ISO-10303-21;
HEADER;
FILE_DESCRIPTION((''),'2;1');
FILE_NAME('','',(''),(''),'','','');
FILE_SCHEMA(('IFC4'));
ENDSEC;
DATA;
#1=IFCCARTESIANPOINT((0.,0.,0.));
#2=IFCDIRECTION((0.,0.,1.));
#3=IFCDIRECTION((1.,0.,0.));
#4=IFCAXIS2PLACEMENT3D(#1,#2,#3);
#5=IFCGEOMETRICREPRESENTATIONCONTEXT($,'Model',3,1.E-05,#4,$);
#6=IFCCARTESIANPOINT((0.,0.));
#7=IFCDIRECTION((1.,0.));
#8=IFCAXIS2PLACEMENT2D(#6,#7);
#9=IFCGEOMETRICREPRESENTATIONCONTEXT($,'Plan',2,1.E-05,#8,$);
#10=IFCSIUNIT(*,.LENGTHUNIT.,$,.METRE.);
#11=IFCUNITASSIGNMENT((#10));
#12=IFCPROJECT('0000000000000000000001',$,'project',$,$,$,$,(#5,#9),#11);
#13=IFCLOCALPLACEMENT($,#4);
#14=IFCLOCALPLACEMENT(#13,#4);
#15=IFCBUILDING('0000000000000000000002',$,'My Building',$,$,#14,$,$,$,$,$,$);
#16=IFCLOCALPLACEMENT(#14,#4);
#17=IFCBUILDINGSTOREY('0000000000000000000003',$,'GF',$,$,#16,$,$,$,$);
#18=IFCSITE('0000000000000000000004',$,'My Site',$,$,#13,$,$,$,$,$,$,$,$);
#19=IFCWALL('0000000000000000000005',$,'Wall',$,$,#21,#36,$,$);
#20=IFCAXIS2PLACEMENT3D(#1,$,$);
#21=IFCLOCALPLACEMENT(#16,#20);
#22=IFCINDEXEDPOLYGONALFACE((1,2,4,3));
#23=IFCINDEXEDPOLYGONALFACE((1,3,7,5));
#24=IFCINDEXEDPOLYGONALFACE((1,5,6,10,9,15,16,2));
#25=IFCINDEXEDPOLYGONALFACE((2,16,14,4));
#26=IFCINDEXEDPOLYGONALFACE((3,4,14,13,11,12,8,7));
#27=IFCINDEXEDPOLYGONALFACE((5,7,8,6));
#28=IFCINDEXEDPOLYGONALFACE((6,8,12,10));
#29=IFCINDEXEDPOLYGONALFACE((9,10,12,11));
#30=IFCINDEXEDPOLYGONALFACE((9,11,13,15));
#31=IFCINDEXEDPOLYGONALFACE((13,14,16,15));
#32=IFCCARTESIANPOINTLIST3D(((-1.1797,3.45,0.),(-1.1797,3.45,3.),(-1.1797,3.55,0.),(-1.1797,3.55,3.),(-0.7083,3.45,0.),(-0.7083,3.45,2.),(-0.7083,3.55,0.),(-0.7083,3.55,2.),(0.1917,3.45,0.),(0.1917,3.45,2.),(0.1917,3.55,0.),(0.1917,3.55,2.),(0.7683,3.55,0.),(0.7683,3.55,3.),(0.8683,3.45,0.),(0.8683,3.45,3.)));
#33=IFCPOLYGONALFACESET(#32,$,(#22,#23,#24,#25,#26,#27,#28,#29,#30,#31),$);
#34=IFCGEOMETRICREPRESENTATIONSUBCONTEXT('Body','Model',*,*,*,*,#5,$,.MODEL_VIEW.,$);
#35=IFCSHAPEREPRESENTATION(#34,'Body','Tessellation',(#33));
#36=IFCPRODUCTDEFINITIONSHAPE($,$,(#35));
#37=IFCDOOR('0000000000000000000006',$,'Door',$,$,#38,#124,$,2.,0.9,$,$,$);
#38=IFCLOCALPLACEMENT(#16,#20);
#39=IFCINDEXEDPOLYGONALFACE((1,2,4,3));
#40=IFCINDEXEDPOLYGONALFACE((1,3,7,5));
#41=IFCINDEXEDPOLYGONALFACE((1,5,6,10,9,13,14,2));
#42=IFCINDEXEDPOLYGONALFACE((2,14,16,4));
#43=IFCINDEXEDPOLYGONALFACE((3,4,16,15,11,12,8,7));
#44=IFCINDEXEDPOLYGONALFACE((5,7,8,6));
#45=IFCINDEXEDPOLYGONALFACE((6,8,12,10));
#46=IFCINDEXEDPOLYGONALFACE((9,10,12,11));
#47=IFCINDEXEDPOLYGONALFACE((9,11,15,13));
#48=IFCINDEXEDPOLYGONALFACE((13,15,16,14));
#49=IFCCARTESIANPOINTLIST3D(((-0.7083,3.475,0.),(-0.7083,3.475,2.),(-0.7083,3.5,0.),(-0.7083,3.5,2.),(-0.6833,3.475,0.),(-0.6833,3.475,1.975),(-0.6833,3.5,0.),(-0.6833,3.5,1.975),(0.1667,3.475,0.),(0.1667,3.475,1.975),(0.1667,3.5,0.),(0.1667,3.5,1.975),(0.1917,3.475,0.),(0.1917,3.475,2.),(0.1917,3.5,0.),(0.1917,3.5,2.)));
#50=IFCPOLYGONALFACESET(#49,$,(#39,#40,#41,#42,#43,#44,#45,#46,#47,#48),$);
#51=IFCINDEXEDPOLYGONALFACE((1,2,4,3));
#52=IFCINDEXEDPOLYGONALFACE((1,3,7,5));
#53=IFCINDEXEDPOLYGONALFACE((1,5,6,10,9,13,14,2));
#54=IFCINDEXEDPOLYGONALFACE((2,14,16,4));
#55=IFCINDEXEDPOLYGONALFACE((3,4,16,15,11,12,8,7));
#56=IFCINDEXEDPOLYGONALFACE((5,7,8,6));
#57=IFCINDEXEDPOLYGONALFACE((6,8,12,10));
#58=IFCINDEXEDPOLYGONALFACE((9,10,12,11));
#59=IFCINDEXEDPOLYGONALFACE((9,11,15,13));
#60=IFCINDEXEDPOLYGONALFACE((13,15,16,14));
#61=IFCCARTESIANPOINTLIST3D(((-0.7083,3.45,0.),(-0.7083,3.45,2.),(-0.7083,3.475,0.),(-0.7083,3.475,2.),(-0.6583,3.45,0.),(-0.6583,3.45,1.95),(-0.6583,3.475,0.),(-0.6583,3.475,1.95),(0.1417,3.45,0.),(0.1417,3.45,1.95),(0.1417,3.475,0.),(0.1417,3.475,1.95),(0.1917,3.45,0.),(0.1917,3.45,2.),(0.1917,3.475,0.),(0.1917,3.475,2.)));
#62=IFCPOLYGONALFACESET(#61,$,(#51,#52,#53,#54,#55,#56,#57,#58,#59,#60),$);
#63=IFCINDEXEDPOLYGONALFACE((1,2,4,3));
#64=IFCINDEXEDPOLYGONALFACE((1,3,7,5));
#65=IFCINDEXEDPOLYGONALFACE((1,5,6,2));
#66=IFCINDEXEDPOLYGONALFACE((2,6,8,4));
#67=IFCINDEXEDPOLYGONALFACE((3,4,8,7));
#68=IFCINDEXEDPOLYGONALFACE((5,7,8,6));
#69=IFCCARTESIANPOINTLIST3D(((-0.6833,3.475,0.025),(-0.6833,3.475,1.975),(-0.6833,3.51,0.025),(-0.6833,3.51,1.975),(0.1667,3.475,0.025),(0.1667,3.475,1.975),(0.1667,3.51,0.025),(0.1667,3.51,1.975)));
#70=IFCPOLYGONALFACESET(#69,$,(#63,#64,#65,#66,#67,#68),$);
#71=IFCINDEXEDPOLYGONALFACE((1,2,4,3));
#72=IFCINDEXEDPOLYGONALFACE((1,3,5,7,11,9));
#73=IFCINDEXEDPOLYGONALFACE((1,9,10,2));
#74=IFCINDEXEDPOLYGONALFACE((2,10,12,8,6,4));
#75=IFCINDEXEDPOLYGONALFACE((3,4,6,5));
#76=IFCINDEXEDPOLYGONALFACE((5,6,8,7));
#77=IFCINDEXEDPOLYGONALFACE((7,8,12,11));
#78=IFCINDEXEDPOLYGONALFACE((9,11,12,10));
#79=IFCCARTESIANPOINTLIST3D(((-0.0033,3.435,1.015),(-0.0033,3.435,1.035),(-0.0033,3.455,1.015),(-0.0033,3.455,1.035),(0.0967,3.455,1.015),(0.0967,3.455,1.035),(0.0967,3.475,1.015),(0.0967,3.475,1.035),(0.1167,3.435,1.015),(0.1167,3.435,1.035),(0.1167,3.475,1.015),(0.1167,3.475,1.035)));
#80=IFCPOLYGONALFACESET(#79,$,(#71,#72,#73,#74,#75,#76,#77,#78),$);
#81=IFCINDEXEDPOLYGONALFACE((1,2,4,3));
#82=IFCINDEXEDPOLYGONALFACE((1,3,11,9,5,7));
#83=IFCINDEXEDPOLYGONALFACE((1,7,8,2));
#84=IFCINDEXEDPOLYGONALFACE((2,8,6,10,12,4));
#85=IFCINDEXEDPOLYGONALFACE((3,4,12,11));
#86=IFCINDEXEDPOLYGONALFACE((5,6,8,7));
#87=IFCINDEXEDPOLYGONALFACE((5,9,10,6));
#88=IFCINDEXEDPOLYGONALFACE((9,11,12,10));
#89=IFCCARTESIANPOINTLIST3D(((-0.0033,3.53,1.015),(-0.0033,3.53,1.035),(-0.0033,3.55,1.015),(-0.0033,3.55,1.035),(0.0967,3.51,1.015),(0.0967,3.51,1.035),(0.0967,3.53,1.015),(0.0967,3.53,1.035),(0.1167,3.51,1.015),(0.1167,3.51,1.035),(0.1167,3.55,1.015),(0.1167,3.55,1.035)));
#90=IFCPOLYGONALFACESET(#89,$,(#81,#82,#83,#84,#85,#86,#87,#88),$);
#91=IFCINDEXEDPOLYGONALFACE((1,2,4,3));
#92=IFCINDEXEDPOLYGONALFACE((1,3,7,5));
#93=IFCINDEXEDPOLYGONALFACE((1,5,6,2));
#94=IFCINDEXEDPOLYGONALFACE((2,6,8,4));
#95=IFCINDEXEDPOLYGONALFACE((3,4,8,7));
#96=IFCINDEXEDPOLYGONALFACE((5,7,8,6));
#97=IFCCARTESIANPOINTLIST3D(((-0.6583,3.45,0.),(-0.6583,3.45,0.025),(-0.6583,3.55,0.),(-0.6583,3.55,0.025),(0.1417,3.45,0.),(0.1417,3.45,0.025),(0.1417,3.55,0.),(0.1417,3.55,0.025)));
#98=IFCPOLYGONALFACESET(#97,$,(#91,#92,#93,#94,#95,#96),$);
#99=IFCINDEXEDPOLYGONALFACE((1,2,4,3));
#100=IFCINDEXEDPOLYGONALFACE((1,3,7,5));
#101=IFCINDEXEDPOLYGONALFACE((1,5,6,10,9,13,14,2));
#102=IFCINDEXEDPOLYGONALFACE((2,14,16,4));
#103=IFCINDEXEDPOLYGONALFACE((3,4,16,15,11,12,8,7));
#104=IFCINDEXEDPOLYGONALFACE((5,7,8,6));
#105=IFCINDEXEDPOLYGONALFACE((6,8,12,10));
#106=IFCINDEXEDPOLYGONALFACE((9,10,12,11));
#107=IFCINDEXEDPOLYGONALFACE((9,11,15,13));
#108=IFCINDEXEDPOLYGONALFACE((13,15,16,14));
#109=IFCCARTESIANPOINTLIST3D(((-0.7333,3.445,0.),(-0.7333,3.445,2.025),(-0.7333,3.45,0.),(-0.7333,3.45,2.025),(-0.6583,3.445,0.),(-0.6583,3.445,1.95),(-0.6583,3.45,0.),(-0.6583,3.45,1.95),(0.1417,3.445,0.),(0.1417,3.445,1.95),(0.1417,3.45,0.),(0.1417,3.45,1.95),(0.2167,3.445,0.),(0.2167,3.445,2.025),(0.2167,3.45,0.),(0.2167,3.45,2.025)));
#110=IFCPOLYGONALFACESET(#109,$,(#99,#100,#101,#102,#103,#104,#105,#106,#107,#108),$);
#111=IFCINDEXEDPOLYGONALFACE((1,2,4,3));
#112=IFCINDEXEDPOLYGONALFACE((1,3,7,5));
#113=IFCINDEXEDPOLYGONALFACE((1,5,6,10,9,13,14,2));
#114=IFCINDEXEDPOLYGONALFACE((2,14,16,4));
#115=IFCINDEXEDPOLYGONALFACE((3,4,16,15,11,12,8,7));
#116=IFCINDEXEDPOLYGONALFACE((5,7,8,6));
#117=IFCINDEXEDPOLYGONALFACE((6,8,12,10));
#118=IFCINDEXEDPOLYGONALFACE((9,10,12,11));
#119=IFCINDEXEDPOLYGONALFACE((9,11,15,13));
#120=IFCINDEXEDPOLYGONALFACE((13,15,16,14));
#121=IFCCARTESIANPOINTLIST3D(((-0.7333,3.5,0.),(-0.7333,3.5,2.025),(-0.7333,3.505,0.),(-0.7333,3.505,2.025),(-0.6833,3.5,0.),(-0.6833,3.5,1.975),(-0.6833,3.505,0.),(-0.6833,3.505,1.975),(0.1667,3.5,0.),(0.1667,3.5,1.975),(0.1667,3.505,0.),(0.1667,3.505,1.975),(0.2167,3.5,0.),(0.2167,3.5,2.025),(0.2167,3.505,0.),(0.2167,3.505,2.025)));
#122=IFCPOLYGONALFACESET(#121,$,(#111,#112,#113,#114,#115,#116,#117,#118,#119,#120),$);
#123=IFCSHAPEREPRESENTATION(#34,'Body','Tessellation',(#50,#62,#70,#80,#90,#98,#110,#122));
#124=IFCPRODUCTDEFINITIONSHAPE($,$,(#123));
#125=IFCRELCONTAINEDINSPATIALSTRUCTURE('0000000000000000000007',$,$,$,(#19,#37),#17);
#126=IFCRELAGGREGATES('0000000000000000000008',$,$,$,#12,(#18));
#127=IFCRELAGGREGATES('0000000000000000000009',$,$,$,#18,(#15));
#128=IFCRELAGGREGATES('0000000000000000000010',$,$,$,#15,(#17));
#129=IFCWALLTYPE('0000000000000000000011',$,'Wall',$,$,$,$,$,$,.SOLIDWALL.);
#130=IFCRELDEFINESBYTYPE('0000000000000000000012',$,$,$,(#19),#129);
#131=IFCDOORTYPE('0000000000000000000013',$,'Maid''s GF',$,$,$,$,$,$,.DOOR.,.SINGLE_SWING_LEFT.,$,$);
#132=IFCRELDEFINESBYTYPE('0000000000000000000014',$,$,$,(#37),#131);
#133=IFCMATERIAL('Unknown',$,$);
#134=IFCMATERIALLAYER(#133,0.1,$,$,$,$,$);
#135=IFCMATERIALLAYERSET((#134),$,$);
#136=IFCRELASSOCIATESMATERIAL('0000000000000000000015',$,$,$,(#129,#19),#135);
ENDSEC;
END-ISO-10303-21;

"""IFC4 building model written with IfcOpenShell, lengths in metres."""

from ifc_helpers import new_model, entity, si_unit, frame, origin_with_axes, origin_2d_with_axis, place, context, subcontext, project, spatial, line, indexed_curve, outline, extrude, shape, source, transform, mapped, material, layer, layer_set, layer_usage, type_object, type_shapes, element, fill, save


model = new_model("IFC4")

# Units and contexts
model_context = context("Model", 3, precision=1e-05, world=origin_with_axes())
plan_context = context("Plan", 2, precision=1e-05, world=origin_2d_with_axis())
body_context_1 = subcontext(model_context, "Body", "Model", "MODEL_VIEW")
body_context_2 = subcontext(plan_context, "Body", "Plan", "PLAN_VIEW")
ifc_project = project(units=[si_unit("LENGTHUNIT", "METRE")], contexts=[model_context, plan_context])

# Site, building, storey
site_placement = place(None, origin_with_axes())
site = spatial("IfcSite", under=ifc_project, at=site_placement, Name="My Site")
building_placement = place(site_placement, origin_with_axes())
building = spatial("IfcBuilding", under=site, at=building_placement, Name="My Building")
storey_placement = place(building_placement, origin_with_axes())
storey = spatial("IfcBuildingStorey", under=building, at=storey_placement, Name="GF")

# Shared definitions
ifc_material = material(Name="Unknown")

# Shared definitions
ifc_layer_1 = layer(ifc_material, 0.1)
ifc_layer_set_1 = layer_set([ifc_layer_1])
wall_type = type_object("IfcWallType", Name="Wall", PredefinedType="SOLIDWALL", material=ifc_layer_set_1)

# Wall, opening, door
ifc_layer_usage_1 = layer_usage(ifc_layer_set_1, "AXIS2", "POSITIVE", 0.0)
wall_1_placement = place(storey_placement, frame((0.7683, 3.55, 0.0), z_axis=(0.0, 0.0, 1.0), x_axis=(-1.0, 0.0, 0.0)))
wall_1 = element("IfcWall", 1, at=wall_1_placement, inside=storey, type_object=wall_type, material=ifc_layer_usage_1, Name="Wall", context=body_context_1, shape_type="SweptSolid", body=[
    extrude(outline(indexed_curve([(0.0, 0.0), (-0.1, 0.1), (1.948, 0.1), (1.948, 0.0)], segments=[line(1, 2, 3, 4, 1)])), origin_with_axes(), (0.0, 0.0, 1.0), 3.0),
])
shared_shape_1 = source(origin_with_axes(), body_context_1, "Body", "SweptSolid", [
    extrude(outline(indexed_curve([(0.0, 0.0), (0.9, 0.0), (0.9, 2.0), (0.0, 2.0)], segments=[line(1, 2, 3, 4, 1)])), frame((0.0, -0.6, 0.0), z_axis=(0.0, -1.0, 0.0), x_axis=(1.0, 0.0, 0.0)), (0.0, 0.0, -1.0), 1.2),
])
opening_1_placement = place(wall_1_placement, frame((1.4766, 0.1, 0.0), z_axis=(0.0, 0.0, 1.0), x_axis=(-1.0, 0.0, 0.0)))
opening_1 = element("IfcOpeningElement", 2, at=opening_1_placement, cuts=wall_1, PredefinedType="OPENING", context=body_context_1, shape_type="MappedRepresentation", body=[
    mapped(shared_shape_1, transform((0.0, 0.0, 0.0), x_axis=(1.0, 0.0, 0.0), y_axis=(0.0, 1.0, 0.0), z_axis=(0.0, 0.0, 1.0), scale=1.0)),
])
door_type_1 = type_object("IfcDoorType", Name="Maid's GF", OperationType="SINGLE_SWING_LEFT", PredefinedType="DOOR")
shared_shape_2 = source(origin_with_axes(), body_context_1, "Body", "SweptSolid", [
    extrude(outline(indexed_curve([(0.0, 0.0), (0.0, 2.0), (0.9, 2.0), (0.9, 0.0), (0.875, 0.0), (0.875, 1.975), (0.025, 1.975), (0.025, 0.0)], segments=[line(1, 2, 3, 4, 5, 6, 7, 8, 1)])), frame((0.0, 0.025, 0.0), z_axis=(0.0, -1.0, 0.0), x_axis=(1.0, 0.0, 0.0)), (0.0, 0.0, -1.0), 0.025),
    extrude(outline(indexed_curve([(0.0, 0.0), (0.0, 2.0), (0.9, 2.0), (0.9, 0.0), (0.85, 0.0), (0.85, 1.95), (0.05, 1.95), (0.05, 0.0)], segments=[line(1, 2, 3, 4, 5, 6, 7, 8, 1)])), frame((0.0, 0.0, 0.0), z_axis=(0.0, -1.0, 0.0), x_axis=(1.0, 0.0, 0.0)), (0.0, 0.0, -1.0), 0.025),
    extrude(outline(indexed_curve([(0.0, 0.0), (0.85, 0.0), (0.85, 0.035), (0.0, 0.035)], segments=[line(1, 2, 3, 4, 1)])), frame((0.025, 0.025, 0.025), z_axis=(0.0, 0.0, 1.0), x_axis=(1.0, 0.0, 0.0)), (0.0, 0.0, 1.0), 1.95),
    extrude(outline(indexed_curve([(0.0, 0.0), (0.0, -0.04), (-0.12, -0.04), (-0.12, -0.02), (-0.02, -0.02), (-0.02, 0.0)], segments=[line(1, 2, 3, 4, 5, 6, 1)])), frame((0.825, 0.025, 1.015), z_axis=(0.0, 0.0, 1.0), x_axis=(1.0, 0.0, 0.0)), (0.0, 0.0, 1.0), 0.02),
    extrude(outline(indexed_curve([(0.0, 0.0), (0.0, 0.04), (-0.12, 0.04), (-0.12, 0.02), (-0.02, 0.02), (-0.02, 0.0)], segments=[line(1, 2, 3, 4, 5, 6, 1)])), frame((0.825, 0.06, 1.015), z_axis=(0.0, 0.0, 1.0), x_axis=(1.0, 0.0, 0.0)), (0.0, 0.0, 1.0), 0.02),
    extrude(outline(indexed_curve([(0.0, 0.0), (0.8, 0.0), (0.8, 0.1), (0.0, 0.1)], segments=[line(1, 2, 3, 4, 1)])), frame((0.05, 0.0, 0.0), z_axis=(0.0, 0.0, 1.0), x_axis=(1.0, 0.0, 0.0)), (0.0, 0.0, 1.0), 0.025),
    extrude(outline(indexed_curve([(0.0, 0.0), (0.0, 2.025), (0.95, 2.025), (0.95, 0.0), (0.875, 0.0), (0.875, 1.95), (0.075, 1.95), (0.075, 0.0)], segments=[line(1, 2, 3, 4, 5, 6, 7, 8, 1)])), frame((-0.025, -0.005, 0.0), z_axis=(0.0, -1.0, 0.0), x_axis=(1.0, 0.0, 0.0)), (0.0, 0.0, -1.0), 0.005),
    extrude(outline(indexed_curve([(0.0, 0.0), (0.0, 2.025), (0.95, 2.025), (0.95, 0.0), (0.9, 0.0), (0.9, 1.975), (0.05, 1.975), (0.05, 0.0)], segments=[line(1, 2, 3, 4, 5, 6, 7, 8, 1)])), frame((-0.025, 0.05, 0.0), z_axis=(0.0, -1.0, 0.0), x_axis=(1.0, 0.0, 0.0)), (0.0, 0.0, -1.0), 0.005),
])
shared_shape_3 = source(origin_with_axes(), body_context_2, "Body", "Curve2D", [
    entity("IfcIndexedPolyCurve", entity("IfcCartesianPointList2D", [[0.0, 0.0], [0.0, 0.05], [0.025, 0.05], [0.025, 0.025], [0.05, 0.025], [0.05, 0.0]]), [entity("IfcLineIndex", [1, 2, 3, 4, 5, 6, 1])]),
    entity("IfcIndexedPolyCurve", entity("IfcCartesianPointList2D", [[0.9, 0.0], [0.9, 0.05], [0.875, 0.05], [0.875, 0.025], [0.85, 0.025], [0.85, 0.0]]), [entity("IfcLineIndex", [1, 2, 3, 4, 5, 6, 1])]),
    entity("IfcTrimmedCurve", entity("IfcEllipse", entity("IfcAxis2Placement2D", entity("IfcCartesianPoint", [0.06, 0.05]), entity("IfcDirection", [1.0, 0.0])), 0.815, 0.85), [entity("IfcCartesianPoint", [0.875, 0.05])], [entity("IfcCartesianPoint", [0.06, 0.9])], True, "CARTESIAN"),
    entity("IfcIndexedPolyCurve", entity("IfcCartesianPointList2D", [[0.025, 0.05], [0.06, 0.05], [0.06, 0.9], [0.025, 0.9]]), [entity("IfcLineIndex", [1, 2, 3, 4, 1])]),
])
type_shapes(door_type_1, [shared_shape_2, shared_shape_3])
door_1_placement = place(opening_1_placement, frame((0.0, 0.0, 0.0), z_axis=(0.0, 0.0, 1.0), x_axis=(1.0, 0.0, 0.0)))
door_1 = element("IfcDoor", 3, at=door_1_placement, inside=storey, type_object=door_type_1, Name="Door", OverallHeight=2.0, OverallWidth=0.9, shapes=[
    shape(body_context_1, "Body", "MappedRepresentation", [mapped(shared_shape_2, transform((0.0, 0.0, 0.0), x_axis=(1.0, 0.0, 0.0), y_axis=(0.0, 1.0, 0.0), z_axis=(0.0, 0.0, 1.0), scale=1.0))]),
    shape(body_context_2, "Body", "MappedRepresentation", [mapped(shared_shape_3, transform((0.0, 0.0, 0.0), x_axis=(1.0, 0.0, 0.0), y_axis=(0.0, 1.0, 0.0), z_axis=(0.0, 0.0, 1.0), scale=1.0))]),
])
fill(opening_1, door_1)

save(model, "model.ifc")
